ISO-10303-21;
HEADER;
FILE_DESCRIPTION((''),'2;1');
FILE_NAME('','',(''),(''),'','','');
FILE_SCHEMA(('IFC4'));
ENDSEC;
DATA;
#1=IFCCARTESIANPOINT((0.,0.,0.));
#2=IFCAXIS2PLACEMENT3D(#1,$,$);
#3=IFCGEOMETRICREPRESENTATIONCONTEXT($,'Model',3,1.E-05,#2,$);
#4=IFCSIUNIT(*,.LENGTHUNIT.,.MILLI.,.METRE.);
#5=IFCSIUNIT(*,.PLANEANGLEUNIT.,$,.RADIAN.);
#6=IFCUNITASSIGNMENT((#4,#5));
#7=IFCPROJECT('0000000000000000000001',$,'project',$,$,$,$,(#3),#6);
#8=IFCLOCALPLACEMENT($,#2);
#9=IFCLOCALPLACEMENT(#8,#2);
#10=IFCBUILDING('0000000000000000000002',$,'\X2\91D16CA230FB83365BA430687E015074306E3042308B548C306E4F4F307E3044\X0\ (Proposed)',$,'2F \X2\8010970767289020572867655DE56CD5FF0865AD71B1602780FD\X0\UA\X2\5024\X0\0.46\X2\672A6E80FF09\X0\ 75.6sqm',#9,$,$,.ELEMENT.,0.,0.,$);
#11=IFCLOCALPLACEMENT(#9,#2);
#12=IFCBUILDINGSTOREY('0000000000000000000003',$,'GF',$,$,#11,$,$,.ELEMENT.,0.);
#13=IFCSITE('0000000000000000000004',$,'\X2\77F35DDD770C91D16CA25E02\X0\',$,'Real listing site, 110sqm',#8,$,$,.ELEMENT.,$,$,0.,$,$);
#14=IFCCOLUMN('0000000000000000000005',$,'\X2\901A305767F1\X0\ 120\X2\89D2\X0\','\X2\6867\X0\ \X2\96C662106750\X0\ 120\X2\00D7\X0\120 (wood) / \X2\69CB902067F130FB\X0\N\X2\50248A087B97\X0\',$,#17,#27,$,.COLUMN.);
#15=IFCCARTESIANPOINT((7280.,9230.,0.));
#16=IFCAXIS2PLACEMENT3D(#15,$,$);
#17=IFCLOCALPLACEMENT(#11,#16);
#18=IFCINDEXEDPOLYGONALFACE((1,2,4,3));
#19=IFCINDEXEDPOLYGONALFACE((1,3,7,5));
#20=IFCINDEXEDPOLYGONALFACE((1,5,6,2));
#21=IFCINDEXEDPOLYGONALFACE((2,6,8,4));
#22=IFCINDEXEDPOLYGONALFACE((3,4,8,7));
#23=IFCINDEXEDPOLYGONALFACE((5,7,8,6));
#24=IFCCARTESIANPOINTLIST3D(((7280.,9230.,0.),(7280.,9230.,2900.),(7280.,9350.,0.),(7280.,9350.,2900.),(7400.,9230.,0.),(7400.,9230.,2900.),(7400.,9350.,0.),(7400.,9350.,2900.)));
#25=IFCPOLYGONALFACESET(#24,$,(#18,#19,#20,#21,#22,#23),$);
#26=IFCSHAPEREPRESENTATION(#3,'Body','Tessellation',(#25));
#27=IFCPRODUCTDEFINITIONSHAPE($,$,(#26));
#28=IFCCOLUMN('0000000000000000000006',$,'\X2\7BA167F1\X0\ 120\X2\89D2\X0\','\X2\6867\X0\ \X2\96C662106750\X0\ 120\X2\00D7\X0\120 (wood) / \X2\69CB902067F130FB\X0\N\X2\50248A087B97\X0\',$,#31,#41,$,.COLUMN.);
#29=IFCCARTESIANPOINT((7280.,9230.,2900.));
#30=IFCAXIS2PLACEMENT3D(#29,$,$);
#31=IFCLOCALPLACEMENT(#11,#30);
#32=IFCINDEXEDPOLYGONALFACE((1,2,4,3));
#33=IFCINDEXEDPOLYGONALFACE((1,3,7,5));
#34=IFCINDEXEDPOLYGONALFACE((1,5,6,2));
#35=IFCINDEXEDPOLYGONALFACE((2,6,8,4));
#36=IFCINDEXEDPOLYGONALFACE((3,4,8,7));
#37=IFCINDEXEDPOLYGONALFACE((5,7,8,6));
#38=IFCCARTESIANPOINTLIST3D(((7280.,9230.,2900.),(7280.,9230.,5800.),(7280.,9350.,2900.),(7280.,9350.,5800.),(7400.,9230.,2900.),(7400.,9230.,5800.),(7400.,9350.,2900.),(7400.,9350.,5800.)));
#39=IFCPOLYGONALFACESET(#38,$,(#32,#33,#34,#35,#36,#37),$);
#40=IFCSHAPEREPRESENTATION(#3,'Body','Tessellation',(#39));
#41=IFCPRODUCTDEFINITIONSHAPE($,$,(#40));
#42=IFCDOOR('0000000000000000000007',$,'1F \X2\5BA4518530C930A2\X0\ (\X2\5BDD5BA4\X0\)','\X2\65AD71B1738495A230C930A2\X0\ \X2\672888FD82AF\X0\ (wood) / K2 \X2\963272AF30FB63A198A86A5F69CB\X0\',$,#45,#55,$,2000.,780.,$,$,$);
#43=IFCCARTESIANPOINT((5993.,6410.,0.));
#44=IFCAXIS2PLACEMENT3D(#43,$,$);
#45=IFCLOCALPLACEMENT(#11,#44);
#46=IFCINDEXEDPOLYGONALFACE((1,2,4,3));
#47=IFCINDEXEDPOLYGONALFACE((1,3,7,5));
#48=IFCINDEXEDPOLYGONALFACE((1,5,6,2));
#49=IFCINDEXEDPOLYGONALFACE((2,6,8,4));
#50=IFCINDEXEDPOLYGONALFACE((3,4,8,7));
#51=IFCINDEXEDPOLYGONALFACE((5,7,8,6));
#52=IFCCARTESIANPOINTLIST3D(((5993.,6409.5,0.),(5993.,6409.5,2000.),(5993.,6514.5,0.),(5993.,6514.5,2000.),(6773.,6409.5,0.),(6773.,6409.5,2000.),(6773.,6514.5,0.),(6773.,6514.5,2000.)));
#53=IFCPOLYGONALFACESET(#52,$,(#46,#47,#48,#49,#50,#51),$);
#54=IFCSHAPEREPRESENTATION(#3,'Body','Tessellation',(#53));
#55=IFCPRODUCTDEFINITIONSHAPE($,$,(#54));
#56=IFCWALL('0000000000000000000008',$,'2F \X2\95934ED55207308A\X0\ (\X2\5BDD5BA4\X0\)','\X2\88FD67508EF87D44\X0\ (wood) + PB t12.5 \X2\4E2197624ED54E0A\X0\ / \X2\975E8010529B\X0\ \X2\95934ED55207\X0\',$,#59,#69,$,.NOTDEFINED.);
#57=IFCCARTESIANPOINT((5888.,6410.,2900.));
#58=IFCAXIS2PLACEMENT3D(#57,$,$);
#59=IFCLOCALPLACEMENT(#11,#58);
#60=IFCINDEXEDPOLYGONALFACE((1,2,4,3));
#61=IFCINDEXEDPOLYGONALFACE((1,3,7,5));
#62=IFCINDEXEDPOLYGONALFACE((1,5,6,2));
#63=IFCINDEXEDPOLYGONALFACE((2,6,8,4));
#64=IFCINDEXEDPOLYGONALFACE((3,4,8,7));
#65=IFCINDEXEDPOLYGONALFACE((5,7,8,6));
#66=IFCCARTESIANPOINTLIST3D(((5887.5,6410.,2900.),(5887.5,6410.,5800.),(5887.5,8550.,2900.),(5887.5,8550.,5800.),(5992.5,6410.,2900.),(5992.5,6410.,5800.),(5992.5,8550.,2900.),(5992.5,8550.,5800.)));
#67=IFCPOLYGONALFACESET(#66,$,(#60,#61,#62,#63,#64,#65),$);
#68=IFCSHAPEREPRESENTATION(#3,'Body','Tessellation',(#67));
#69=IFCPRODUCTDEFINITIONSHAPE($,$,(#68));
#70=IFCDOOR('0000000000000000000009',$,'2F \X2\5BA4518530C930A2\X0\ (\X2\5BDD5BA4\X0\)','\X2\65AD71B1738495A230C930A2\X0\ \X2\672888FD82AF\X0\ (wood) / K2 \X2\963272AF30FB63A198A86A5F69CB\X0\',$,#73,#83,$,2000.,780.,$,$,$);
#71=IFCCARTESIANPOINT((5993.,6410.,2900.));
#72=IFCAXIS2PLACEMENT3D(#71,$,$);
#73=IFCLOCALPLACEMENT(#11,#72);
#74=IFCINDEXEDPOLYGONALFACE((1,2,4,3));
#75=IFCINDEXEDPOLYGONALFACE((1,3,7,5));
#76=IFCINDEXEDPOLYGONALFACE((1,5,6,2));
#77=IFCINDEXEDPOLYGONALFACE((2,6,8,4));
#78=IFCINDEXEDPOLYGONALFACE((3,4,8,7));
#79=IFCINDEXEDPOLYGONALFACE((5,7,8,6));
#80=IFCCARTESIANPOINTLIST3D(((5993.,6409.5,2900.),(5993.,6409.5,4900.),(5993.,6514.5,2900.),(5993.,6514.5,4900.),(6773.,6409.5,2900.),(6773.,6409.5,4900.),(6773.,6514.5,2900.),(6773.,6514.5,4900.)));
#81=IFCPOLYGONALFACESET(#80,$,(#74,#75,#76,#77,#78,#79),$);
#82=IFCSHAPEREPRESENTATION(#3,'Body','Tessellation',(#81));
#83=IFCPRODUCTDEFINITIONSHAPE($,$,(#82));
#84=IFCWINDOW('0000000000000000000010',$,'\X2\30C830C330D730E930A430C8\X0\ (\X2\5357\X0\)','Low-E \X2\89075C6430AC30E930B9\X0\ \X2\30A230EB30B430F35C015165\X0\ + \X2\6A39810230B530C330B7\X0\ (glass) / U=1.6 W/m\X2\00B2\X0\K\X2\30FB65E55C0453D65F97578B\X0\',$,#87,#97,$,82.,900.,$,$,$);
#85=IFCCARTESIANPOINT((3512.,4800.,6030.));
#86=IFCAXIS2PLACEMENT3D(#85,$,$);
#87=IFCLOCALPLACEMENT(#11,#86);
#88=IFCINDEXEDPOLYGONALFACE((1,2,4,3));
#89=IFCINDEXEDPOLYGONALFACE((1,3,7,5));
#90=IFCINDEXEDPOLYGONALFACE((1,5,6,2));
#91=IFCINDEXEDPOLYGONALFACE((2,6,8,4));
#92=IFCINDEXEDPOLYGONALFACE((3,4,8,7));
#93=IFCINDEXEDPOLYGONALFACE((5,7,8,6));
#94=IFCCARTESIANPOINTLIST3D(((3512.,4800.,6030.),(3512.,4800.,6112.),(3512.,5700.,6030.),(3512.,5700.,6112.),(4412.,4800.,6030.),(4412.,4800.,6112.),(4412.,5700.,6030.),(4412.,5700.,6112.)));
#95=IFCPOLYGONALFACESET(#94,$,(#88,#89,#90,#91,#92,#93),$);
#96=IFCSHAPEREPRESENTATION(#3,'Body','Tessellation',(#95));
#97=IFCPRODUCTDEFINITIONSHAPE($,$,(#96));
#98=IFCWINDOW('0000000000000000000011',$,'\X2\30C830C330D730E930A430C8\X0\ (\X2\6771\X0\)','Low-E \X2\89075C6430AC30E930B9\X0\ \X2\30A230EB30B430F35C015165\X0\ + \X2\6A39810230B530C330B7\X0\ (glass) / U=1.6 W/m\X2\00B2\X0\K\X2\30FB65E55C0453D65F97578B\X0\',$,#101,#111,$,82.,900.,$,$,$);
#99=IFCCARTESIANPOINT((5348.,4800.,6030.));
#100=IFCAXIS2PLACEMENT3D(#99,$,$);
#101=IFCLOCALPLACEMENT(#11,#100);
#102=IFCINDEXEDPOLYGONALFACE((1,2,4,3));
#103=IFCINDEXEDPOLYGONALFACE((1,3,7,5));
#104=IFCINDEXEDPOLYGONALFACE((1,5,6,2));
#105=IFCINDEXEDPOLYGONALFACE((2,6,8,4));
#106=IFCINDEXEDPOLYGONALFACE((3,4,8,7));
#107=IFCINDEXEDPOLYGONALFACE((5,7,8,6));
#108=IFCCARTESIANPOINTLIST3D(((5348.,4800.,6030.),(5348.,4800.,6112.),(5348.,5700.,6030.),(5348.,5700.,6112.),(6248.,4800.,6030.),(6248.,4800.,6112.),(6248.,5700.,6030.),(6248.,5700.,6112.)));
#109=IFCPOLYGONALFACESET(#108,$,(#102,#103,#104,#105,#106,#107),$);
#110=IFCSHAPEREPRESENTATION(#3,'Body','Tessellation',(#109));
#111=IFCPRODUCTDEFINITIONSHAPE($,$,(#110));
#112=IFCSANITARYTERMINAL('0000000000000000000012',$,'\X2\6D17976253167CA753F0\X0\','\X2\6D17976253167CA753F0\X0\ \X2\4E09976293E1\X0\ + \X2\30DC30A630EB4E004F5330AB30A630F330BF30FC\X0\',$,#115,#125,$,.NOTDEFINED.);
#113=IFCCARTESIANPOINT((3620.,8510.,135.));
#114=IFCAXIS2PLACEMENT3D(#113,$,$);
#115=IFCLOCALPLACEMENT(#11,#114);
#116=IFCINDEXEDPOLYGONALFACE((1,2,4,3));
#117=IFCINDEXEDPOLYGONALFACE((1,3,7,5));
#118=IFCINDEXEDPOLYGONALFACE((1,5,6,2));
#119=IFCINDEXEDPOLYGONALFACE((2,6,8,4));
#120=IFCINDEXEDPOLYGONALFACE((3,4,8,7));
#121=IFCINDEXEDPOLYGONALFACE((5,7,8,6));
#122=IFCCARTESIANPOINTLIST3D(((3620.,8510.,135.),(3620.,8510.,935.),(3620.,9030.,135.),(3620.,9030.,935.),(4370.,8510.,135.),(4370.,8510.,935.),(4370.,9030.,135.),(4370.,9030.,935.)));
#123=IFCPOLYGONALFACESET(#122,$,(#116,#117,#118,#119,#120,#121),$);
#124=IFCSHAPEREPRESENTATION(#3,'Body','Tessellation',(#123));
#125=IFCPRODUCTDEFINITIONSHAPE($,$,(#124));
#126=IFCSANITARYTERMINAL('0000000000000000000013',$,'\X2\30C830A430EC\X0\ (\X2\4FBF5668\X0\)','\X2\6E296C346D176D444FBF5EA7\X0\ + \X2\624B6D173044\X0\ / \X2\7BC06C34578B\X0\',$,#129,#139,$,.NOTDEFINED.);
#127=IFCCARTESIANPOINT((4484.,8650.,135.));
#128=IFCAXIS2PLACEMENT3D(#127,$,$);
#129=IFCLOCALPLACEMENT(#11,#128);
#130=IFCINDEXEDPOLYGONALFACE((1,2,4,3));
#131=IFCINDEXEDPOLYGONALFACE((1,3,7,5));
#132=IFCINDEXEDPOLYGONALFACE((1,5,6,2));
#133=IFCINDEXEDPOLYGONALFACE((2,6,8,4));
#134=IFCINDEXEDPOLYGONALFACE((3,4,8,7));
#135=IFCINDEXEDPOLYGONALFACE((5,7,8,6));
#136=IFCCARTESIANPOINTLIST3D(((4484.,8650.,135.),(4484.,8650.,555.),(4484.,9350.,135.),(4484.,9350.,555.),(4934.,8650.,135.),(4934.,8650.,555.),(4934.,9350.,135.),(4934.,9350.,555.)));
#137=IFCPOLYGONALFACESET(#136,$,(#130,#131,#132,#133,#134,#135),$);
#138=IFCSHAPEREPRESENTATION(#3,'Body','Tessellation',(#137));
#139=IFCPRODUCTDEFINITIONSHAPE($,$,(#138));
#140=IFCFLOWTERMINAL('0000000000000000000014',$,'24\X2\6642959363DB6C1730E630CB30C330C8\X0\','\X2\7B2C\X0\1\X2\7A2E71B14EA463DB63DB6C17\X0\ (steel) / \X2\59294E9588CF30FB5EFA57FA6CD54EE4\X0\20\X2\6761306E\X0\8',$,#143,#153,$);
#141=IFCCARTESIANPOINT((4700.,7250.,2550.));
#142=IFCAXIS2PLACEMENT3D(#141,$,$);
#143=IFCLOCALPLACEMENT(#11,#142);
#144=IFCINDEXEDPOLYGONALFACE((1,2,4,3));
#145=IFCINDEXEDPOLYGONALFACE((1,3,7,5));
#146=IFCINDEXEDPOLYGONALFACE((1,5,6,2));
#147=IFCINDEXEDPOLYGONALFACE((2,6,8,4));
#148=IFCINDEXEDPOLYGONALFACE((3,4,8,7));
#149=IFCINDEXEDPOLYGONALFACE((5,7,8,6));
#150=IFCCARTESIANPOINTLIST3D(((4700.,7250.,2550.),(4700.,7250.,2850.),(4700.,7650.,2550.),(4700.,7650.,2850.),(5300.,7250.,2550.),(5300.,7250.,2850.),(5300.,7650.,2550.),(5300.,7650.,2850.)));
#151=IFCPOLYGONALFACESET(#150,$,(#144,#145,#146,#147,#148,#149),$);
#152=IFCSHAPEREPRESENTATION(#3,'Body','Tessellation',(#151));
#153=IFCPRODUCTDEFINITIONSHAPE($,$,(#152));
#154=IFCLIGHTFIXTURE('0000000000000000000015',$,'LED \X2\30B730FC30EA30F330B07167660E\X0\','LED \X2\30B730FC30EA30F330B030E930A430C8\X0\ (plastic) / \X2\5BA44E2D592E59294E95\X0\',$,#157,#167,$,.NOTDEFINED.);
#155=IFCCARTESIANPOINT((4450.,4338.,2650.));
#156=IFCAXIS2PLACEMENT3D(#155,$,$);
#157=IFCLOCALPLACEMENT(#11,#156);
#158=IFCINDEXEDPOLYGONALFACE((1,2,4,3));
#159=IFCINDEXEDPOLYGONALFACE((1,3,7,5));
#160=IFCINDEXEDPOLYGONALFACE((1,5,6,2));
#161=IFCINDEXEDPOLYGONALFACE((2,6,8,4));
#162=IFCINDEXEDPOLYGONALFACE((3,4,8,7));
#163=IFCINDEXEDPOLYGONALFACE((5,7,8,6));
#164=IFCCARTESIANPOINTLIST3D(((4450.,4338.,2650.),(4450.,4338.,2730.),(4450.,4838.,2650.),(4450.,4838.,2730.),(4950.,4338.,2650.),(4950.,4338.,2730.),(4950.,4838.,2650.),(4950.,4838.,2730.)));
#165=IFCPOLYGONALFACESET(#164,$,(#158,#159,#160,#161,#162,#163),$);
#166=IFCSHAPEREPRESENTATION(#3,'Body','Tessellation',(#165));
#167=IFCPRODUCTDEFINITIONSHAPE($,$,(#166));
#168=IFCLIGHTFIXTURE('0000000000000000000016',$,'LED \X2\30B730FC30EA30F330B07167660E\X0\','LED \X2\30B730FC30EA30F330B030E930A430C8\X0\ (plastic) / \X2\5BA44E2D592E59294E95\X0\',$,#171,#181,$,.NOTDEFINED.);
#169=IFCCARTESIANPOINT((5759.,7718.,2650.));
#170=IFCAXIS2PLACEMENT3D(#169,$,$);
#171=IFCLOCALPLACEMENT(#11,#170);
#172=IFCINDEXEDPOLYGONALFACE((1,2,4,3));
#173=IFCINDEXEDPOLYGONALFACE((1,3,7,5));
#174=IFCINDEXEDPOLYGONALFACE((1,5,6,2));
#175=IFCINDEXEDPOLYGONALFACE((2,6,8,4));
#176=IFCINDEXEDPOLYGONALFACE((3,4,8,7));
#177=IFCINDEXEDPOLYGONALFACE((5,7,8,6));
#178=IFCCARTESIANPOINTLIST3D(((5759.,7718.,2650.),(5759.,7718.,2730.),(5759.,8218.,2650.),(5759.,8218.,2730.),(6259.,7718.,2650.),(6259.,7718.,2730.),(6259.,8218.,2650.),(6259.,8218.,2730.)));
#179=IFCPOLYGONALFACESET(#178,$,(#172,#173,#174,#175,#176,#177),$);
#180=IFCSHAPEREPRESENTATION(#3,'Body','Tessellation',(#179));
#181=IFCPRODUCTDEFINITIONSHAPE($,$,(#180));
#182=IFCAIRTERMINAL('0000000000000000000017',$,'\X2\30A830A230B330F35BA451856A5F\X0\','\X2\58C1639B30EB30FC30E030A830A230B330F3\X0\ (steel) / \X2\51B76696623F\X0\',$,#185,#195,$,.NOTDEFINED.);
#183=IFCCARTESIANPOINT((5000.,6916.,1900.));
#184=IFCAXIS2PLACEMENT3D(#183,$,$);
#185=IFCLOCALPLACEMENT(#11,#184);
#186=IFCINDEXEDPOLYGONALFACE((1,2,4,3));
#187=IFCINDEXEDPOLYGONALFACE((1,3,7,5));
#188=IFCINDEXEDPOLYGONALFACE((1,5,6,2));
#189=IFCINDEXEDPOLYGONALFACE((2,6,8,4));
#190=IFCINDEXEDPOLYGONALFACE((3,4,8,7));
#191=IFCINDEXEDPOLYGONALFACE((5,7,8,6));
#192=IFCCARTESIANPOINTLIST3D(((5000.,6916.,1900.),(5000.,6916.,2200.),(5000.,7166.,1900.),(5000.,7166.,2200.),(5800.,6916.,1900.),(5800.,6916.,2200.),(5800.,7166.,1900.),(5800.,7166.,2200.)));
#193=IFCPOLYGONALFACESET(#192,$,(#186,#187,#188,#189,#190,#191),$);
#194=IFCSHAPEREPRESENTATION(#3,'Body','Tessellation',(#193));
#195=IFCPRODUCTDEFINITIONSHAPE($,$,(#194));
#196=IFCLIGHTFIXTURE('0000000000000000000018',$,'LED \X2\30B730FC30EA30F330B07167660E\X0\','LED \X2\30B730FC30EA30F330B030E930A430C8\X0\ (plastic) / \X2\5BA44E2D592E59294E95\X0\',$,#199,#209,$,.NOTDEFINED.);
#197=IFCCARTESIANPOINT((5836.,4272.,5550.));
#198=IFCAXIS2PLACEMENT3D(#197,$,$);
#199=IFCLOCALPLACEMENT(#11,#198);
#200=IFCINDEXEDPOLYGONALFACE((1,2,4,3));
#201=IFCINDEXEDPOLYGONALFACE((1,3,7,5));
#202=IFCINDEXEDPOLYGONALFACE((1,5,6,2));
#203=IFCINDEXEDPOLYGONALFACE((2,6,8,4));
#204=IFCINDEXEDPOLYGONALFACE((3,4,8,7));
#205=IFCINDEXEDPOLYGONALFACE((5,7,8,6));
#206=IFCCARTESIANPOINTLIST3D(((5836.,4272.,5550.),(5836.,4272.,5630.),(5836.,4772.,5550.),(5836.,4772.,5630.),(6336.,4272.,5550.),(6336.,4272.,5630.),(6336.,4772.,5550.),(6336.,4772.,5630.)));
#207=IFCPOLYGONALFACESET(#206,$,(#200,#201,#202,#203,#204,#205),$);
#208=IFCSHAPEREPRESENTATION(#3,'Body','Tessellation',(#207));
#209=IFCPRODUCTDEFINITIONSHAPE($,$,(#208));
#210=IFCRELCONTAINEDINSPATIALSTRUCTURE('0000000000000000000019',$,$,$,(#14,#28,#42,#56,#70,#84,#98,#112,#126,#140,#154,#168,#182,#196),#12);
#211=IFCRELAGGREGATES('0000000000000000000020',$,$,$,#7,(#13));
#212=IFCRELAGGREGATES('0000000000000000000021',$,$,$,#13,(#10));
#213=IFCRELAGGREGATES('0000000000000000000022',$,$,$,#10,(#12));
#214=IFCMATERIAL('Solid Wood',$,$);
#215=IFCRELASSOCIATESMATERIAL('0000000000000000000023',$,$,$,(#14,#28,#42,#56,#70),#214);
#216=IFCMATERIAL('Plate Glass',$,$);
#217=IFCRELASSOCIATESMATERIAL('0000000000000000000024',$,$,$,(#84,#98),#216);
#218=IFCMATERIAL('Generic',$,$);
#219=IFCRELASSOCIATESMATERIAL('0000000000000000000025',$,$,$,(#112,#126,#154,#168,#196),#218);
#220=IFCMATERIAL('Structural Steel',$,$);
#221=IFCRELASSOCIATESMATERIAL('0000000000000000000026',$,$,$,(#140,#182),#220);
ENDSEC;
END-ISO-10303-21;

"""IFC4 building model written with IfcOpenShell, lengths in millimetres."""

from ifc_helpers import new_model, si_unit, frame, frame_2d, origin, place, context, project, spatial, rectangle, extrude, material, element, save


model = new_model("IFC4")

# Units and contexts
model_context = context("Model", 3, precision=1e-05, world=origin())
ifc_project = project(units=[si_unit("LENGTHUNIT", "METRE", prefix="MILLI"), si_unit("PLANEANGLEUNIT", "RADIAN")], contexts=[model_context])

# Site, building, storey
site_placement = place(None, origin())
site = spatial("IfcSite", under=ifc_project, at=site_placement, Name="石川県金沢市", ObjectType="Real listing site, 110sqm", CompositionType="ELEMENT", RefElevation=0.0)
building_placement = place(site_placement, origin())
building = spatial("IfcBuilding", under=site, at=building_placement, Name="金沢・茶室と縁側のある和の住まい (Proposed)", ObjectType="2F 耐震木造在来工法（断熱性能UA値0.46未満） 75.6sqm", CompositionType="ELEMENT", ElevationOfRefHeight=0.0, ElevationOfTerrain=0.0)
storey_placement = place(building_placement, origin())
storey = spatial("IfcBuildingStorey", under=building, at=storey_placement, Name="GF", CompositionType="ELEMENT", Elevation=0.0)

# Columns
ifc_material_1 = material(Name="Solid Wood")
column_1_placement = place(storey_placement, frame((7280.0, 9230.0, 0.0)))
element("IfcColumn", 1, at=column_1_placement, inside=storey, material=ifc_material_1, Name="通し柱 120角", Description="桧 集成材 120×120 (wood) / 構造柱・N値計算", PredefinedType="COLUMN", context=model_context, shape_type="SweptSolid", body=[
    extrude(rectangle(XDim=120.0, YDim=120.0, at=frame_2d((60.0, 60.0))), frame((7280.0, 9230.0, 0.0)), (0.0, 0.0, 1.0), 2900.0),
])
column_2_placement = place(storey_placement, frame((7280.0, 9230.0, 2900.0)))
element("IfcColumn", 2, at=column_2_placement, inside=storey, material=ifc_material_1, Name="管柱 120角", Description="桧 集成材 120×120 (wood) / 構造柱・N値計算", PredefinedType="COLUMN", context=model_context, shape_type="SweptSolid", body=[
    extrude(rectangle(XDim=120.0, YDim=120.0, at=frame_2d((60.0, 60.0))), frame((7280.0, 9230.0, 2900.0)), (0.0, 0.0, 1.0), 2900.0),
])

# Door
door_1_placement = place(storey_placement, frame((5993.0, 6410.0, 0.0)))
element("IfcDoor", 3, at=door_1_placement, inside=storey, material=ifc_material_1, Name="1F 室内ドア (寝室)", Description="断熱玄関ドア 木製芯 (wood) / K2 防犯・採風機構", OverallHeight=2000.0, OverallWidth=780.0, context=model_context, shape_type="SweptSolid", body=[
    extrude(rectangle(XDim=780.0, YDim=105.0, at=frame_2d((390.0, 52.0))), frame((5993.0, 6410.0, 0.0)), (0.0, 0.0, 1.0), 2000.0),
])

# Wall
wall_1_placement = place(storey_placement, frame((5888.0, 6410.0, 2900.0)))
element("IfcWall", 4, at=wall_1_placement, inside=storey, material=ifc_material_1, Name="2F 間仕切り (寝室)", Description="製材軸組 (wood) + PB t12.5 両面仕上 / 非耐力 間仕切", PredefinedType="NOTDEFINED", context=model_context, shape_type="SweptSolid", body=[
    extrude(rectangle(XDim=105.0, YDim=2140.0, at=frame_2d((52.0, 1070.0))), frame((5888.0, 6410.0, 2900.0)), (0.0, 0.0, 1.0), 2900.0),
])

# Door
door_2_placement = place(storey_placement, frame((5993.0, 6410.0, 2900.0)))
element("IfcDoor", 5, at=door_2_placement, inside=storey, material=ifc_material_1, Name="2F 室内ドア (寝室)", Description="断熱玄関ドア 木製芯 (wood) / K2 防犯・採風機構", OverallHeight=2000.0, OverallWidth=780.0, context=model_context, shape_type="SweptSolid", body=[
    extrude(rectangle(XDim=780.0, YDim=105.0, at=frame_2d((390.0, 52.0))), frame((5993.0, 6410.0, 2900.0)), (0.0, 0.0, 1.0), 2000.0),
])

# Windows
ifc_material_2 = material(Name="Plate Glass")
window_1_placement = place(storey_placement, frame((3512.0, 4800.0, 6030.0)))
element("IfcWindow", 6, at=window_1_placement, inside=storey, material=ifc_material_2, Name="トップライト (南)", Description="Low-E 複層ガラス アルゴン封入 + 樹脂サッシ (glass) / U=1.6 W/m²K・日射取得型", OverallHeight=82.0, OverallWidth=900.0, context=model_context, shape_type="SweptSolid", body=[
    extrude(rectangle(XDim=900.0, YDim=900.0, at=frame_2d((450.0, 450.0))), frame((3512.0, 4800.0, 6030.0)), (0.0, 0.0, 1.0), 82.0),
])
window_2_placement = place(storey_placement, frame((5348.0, 4800.0, 6030.0)))
element("IfcWindow", 7, at=window_2_placement, inside=storey, material=ifc_material_2, Name="トップライト (東)", Description="Low-E 複層ガラス アルゴン封入 + 樹脂サッシ (glass) / U=1.6 W/m²K・日射取得型", OverallHeight=82.0, OverallWidth=900.0, context=model_context, shape_type="SweptSolid", body=[
    extrude(rectangle(XDim=900.0, YDim=900.0, at=frame_2d((450.0, 450.0))), frame((5348.0, 4800.0, 6030.0)), (0.0, 0.0, 1.0), 82.0),
])

# Sanitary terminals
ifc_material_3 = material(Name="Generic")
sanitary_terminal_1_placement = place(storey_placement, frame((3620.0, 8510.0, 135.0)))
element("IfcSanitaryTerminal", 8, at=sanitary_terminal_1_placement, inside=storey, material=ifc_material_3, Name="洗面化粧台", Description="洗面化粧台 三面鏡 + ボウル一体カウンター", PredefinedType="NOTDEFINED", context=model_context, shape_type="SweptSolid", body=[
    extrude(rectangle(XDim=750.0, YDim=520.0, at=frame_2d((375.0, 260.0))), frame((3620.0, 8510.0, 135.0)), (0.0, 0.0, 1.0), 800.0),
])
sanitary_terminal_2_placement = place(storey_placement, frame((4484.0, 8650.0, 135.0)))
element("IfcSanitaryTerminal", 9, at=sanitary_terminal_2_placement, inside=storey, material=ifc_material_3, Name="トイレ (便器)", Description="温水洗浄便座 + 手洗い / 節水型", PredefinedType="NOTDEFINED", context=model_context, shape_type="SweptSolid", body=[
    extrude(rectangle(XDim=450.0, YDim=700.0, at=frame_2d((225.0, 350.0))), frame((4484.0, 8650.0, 135.0)), (0.0, 0.0, 1.0), 420.0),
])

# Flow terminal
ifc_material_4 = material(Name="Structural Steel")
flow_terminal_placement = place(storey_placement, frame((4700.0, 7250.0, 2550.0)))
element("IfcFlowTerminal", 10, at=flow_terminal_placement, inside=storey, material=ifc_material_4, Name="24時間換気ユニット", Description="第1種熱交換換気 (steel) / 天井裏・建基法令20条の8", context=model_context, shape_type="SweptSolid", body=[
    extrude(rectangle(XDim=600.0, YDim=400.0, at=frame_2d((300.0, 200.0))), frame((4700.0, 7250.0, 2550.0)), (0.0, 0.0, 1.0), 300.0),
])

# Light fixtures
light_fixture_1_placement = place(storey_placement, frame((4450.0, 4338.0, 2650.0)))
element("IfcLightFixture", 11, at=light_fixture_1_placement, inside=storey, material=ifc_material_3, Name="LED シーリング照明", Description="LED シーリングライト (plastic) / 室中央天井", PredefinedType="NOTDEFINED", context=model_context, shape_type="SweptSolid", body=[
    extrude(rectangle(XDim=500.0, YDim=500.0, at=frame_2d((250.0, 250.0))), frame((4450.0, 4338.0, 2650.0)), (0.0, 0.0, 1.0), 80.0),
])
light_fixture_2_placement = place(storey_placement, frame((5759.0, 7718.0, 2650.0)))
element("IfcLightFixture", 12, at=light_fixture_2_placement, inside=storey, material=ifc_material_3, Name="LED シーリング照明", Description="LED シーリングライト (plastic) / 室中央天井", PredefinedType="NOTDEFINED", context=model_context, shape_type="SweptSolid", body=[
    extrude(rectangle(XDim=500.0, YDim=500.0, at=frame_2d((250.0, 250.0))), frame((5759.0, 7718.0, 2650.0)), (0.0, 0.0, 1.0), 80.0),
])

# Air terminal
air_terminal_placement = place(storey_placement, frame((5000.0, 6916.0, 1900.0)))
element("IfcAirTerminal", 13, at=air_terminal_placement, inside=storey, material=ifc_material_4, Name="エアコン室内機", Description="壁掛ルームエアコン (steel) / 冷暖房", PredefinedType="NOTDEFINED", context=model_context, shape_type="SweptSolid", body=[
    extrude(rectangle(XDim=800.0, YDim=250.0, at=frame_2d((400.0, 125.0))), frame((5000.0, 6916.0, 1900.0)), (0.0, 0.0, 1.0), 300.0),
])

# Light fixture
light_fixture_3_placement = place(storey_placement, frame((5836.0, 4272.0, 5550.0)))
element("IfcLightFixture", 14, at=light_fixture_3_placement, inside=storey, material=ifc_material_3, Name="LED シーリング照明", Description="LED シーリングライト (plastic) / 室中央天井", PredefinedType="NOTDEFINED", context=model_context, shape_type="SweptSolid", body=[
    extrude(rectangle(XDim=500.0, YDim=500.0, at=frame_2d((250.0, 250.0))), frame((5836.0, 4272.0, 5550.0)), (0.0, 0.0, 1.0), 80.0),
])

save(model, "model.ifc")
